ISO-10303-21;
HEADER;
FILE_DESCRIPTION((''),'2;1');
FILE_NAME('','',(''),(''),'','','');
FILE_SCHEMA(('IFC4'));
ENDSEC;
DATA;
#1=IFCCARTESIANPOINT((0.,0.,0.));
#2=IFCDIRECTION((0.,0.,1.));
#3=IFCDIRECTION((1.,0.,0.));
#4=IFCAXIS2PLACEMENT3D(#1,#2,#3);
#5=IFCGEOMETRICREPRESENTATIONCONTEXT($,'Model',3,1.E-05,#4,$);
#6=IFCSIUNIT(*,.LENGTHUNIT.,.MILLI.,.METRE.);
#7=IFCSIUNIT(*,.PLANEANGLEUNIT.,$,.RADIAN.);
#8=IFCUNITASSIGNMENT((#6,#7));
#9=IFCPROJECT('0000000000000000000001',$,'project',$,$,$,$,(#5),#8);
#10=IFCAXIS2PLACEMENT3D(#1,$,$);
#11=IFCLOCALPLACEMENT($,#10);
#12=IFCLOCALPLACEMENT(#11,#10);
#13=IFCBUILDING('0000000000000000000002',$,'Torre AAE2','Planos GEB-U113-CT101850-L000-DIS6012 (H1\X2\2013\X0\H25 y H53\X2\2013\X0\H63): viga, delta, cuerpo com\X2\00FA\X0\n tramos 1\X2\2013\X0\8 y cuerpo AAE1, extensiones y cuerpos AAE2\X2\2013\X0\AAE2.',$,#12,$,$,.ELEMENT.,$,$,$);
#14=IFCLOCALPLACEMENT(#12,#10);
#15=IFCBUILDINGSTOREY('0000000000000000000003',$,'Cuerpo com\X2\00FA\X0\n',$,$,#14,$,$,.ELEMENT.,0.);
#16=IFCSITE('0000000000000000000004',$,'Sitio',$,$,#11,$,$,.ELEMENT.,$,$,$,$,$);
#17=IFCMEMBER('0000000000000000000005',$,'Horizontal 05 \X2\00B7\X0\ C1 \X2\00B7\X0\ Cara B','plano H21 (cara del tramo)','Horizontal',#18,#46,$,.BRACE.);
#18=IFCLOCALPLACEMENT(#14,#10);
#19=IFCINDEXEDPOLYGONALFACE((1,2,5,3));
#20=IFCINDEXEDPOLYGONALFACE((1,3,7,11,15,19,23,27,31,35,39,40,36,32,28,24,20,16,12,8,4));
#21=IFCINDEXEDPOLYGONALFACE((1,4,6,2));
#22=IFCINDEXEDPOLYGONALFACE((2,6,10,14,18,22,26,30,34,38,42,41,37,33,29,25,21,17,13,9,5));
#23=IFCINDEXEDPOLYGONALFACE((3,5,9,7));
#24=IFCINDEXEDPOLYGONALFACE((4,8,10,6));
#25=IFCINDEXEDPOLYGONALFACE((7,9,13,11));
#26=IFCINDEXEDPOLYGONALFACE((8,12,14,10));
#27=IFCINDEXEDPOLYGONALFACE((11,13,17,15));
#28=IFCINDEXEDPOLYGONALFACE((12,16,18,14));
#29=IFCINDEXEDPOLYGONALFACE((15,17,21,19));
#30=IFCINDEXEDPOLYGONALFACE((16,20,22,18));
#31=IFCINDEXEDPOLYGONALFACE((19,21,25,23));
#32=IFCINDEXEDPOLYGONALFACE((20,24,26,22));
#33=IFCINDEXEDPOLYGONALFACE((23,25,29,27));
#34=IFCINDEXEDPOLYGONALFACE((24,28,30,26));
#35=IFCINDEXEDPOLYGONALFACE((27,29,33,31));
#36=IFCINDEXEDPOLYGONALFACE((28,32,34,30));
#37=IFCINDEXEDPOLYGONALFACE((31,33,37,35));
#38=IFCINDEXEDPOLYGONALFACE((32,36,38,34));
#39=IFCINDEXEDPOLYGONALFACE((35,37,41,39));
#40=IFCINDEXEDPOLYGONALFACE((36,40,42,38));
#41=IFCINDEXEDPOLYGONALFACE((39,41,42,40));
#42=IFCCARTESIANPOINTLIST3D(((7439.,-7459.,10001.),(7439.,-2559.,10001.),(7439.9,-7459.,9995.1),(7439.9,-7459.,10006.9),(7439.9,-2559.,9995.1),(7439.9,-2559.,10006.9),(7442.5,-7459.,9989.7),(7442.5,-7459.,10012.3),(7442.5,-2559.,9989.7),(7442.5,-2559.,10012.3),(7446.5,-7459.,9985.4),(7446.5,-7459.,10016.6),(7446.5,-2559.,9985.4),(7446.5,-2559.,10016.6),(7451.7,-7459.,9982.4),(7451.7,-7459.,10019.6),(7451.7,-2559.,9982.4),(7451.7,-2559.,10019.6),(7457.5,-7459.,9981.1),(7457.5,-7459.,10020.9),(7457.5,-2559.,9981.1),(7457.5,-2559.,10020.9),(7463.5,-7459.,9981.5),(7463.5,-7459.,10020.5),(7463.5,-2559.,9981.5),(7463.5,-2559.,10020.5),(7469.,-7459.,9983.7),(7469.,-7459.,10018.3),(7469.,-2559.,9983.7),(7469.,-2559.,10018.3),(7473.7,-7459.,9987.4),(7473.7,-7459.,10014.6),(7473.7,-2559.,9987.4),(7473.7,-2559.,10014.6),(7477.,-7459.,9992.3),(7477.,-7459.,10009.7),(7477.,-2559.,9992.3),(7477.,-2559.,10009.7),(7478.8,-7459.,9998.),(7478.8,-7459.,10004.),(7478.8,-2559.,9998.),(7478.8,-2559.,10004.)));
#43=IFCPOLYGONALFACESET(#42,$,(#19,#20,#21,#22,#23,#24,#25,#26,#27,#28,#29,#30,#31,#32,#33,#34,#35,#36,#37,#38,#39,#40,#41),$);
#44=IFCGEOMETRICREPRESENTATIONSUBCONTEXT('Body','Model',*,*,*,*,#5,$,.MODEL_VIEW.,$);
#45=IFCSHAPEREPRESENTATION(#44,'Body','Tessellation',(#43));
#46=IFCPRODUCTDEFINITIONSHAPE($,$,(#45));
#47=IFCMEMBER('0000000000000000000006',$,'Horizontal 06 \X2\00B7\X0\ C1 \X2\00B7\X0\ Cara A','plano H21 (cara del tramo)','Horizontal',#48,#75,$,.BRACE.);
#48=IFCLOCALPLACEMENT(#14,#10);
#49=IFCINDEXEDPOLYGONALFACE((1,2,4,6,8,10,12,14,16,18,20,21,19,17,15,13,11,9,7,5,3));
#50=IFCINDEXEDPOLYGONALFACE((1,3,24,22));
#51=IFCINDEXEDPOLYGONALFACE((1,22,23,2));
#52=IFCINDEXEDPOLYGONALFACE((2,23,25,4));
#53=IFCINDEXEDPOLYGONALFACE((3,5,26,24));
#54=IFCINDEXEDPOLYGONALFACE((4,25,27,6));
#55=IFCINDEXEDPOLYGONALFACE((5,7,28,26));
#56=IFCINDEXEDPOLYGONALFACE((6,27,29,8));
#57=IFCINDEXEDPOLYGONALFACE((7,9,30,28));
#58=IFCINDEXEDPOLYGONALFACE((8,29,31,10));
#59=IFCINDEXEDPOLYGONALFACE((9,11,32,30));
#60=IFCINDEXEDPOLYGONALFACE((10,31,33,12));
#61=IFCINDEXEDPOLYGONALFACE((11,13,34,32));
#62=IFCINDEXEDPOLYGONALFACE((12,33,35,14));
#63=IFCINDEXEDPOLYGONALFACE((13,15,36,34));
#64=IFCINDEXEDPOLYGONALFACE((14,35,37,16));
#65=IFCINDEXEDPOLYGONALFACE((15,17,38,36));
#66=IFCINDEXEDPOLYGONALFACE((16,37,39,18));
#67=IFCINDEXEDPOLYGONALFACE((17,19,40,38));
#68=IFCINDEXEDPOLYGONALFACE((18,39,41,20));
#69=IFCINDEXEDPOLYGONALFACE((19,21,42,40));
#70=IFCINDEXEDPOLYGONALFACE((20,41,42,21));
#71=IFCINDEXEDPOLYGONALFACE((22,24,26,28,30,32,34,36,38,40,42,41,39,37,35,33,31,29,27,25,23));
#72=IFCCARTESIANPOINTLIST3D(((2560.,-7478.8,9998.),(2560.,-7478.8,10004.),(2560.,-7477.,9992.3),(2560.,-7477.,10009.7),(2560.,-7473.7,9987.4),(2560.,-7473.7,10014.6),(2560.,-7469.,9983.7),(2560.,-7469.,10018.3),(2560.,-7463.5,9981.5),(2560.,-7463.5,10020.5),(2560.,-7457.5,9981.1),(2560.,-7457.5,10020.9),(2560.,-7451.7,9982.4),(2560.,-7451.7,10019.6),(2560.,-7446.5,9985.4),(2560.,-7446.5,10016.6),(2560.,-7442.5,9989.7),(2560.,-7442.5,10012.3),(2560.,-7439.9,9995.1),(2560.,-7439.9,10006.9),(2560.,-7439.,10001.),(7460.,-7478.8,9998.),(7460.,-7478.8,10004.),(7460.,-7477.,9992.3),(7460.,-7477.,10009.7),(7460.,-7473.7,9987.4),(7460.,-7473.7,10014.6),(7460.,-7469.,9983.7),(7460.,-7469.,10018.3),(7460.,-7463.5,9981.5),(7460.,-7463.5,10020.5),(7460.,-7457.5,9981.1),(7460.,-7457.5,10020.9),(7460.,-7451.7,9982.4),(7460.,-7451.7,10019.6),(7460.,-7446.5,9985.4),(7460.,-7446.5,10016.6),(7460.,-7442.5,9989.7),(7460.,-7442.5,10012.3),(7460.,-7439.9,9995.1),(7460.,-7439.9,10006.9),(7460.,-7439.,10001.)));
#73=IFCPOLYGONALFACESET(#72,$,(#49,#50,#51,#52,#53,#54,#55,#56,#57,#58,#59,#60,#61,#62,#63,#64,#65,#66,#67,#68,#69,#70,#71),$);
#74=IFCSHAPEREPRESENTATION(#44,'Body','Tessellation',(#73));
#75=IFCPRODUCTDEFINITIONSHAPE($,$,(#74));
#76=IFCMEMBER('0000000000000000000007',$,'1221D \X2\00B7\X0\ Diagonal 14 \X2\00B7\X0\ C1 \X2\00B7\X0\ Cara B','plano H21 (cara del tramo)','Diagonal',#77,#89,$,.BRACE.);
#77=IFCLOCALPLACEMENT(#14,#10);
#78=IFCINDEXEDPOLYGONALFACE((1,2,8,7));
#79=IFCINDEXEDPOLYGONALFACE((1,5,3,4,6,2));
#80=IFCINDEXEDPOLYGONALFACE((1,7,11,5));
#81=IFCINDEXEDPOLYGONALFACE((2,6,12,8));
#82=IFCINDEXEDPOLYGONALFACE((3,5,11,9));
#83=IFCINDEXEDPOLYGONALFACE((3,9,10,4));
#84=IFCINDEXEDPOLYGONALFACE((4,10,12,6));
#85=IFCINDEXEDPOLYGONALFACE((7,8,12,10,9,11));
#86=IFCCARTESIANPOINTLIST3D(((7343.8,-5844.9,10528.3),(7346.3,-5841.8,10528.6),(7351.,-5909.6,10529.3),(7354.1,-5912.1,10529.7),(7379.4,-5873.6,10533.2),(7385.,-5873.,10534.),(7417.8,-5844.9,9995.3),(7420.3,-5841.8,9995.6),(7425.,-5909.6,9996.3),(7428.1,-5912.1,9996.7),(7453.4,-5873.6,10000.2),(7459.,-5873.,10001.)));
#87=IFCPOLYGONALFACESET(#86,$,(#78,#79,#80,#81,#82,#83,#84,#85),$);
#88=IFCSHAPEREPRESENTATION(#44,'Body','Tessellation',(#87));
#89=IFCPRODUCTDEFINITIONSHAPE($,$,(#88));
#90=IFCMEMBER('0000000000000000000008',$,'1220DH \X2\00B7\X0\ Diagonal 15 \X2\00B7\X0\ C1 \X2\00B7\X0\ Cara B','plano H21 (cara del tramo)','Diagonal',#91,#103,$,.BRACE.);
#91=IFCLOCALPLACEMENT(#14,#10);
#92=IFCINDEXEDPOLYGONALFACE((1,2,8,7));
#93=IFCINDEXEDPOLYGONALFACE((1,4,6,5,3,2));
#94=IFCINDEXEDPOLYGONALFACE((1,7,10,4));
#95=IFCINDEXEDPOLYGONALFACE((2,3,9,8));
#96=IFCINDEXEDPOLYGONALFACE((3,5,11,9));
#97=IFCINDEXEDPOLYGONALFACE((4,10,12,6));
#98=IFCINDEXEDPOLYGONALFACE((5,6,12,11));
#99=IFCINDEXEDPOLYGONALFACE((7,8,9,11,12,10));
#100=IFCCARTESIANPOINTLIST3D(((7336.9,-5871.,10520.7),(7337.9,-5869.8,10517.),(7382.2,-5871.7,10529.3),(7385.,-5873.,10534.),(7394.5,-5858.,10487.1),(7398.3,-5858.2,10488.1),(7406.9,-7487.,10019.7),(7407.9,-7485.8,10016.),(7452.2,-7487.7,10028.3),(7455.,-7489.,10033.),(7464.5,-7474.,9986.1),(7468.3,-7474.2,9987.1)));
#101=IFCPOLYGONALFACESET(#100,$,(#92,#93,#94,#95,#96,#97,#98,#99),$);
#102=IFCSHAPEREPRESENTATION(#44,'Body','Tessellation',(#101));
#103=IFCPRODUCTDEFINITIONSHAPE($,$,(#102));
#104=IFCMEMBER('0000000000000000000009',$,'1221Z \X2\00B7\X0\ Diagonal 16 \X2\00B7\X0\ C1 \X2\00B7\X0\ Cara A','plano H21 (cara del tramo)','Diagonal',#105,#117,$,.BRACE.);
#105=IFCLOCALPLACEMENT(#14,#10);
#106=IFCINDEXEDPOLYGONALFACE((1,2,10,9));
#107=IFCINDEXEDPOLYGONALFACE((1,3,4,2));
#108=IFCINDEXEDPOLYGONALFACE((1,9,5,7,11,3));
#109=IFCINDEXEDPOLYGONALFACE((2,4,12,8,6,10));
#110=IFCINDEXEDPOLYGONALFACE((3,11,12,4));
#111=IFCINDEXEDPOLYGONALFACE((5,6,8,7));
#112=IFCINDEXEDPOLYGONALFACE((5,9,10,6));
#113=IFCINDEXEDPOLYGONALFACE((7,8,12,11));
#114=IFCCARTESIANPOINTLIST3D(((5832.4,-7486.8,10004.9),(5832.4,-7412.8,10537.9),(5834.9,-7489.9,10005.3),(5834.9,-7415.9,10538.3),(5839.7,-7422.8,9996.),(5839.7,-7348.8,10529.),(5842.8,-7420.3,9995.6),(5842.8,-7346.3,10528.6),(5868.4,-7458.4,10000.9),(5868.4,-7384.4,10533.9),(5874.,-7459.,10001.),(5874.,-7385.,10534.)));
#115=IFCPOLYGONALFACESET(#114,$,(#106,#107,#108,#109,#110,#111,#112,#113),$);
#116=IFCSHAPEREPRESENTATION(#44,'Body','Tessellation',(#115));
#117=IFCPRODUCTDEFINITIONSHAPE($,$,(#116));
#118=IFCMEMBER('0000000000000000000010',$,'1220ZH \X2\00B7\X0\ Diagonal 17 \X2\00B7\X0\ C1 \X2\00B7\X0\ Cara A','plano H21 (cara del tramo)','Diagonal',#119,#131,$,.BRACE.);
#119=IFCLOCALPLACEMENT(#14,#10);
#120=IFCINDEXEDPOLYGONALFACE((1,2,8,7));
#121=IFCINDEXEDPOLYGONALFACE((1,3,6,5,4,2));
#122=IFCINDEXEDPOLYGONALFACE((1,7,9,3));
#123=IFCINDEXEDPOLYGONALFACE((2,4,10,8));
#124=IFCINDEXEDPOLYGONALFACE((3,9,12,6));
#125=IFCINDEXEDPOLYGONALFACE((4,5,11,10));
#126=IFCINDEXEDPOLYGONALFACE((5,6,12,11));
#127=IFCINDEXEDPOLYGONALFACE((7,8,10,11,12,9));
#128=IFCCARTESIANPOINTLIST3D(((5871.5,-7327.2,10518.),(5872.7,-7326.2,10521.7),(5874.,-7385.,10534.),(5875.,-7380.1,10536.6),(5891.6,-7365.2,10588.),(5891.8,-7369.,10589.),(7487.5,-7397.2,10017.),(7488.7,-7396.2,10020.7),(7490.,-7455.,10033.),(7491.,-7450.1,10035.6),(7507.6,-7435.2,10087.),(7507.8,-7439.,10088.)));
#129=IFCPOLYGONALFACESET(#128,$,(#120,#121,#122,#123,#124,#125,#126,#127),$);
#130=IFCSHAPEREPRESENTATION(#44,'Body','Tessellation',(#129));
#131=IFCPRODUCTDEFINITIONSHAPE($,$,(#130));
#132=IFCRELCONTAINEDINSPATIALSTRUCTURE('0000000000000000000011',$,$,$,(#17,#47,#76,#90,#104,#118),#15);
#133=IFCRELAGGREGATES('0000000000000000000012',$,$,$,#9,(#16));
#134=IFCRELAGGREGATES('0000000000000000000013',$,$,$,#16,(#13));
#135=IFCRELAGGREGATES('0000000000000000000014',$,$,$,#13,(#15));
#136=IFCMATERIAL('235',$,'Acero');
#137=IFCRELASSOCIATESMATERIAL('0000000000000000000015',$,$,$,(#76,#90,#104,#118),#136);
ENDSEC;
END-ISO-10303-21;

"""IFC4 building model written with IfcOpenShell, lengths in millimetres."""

from ifc_helpers import new_model, si_unit, frame, frame_2d, origin, origin_with_axes, place, context, subcontext, project, spatial, circle, l_section, extrude, material, element, save


model = new_model("IFC4")

# Units and contexts
model_context = context("Model", 3, precision=1e-05, world=origin_with_axes())
body_context = subcontext(model_context, "Body", "Model", "MODEL_VIEW")
ifc_project = project(units=[si_unit("LENGTHUNIT", "METRE", prefix="MILLI"), si_unit("PLANEANGLEUNIT", "RADIAN")], contexts=[model_context])

# Site, building, storey
site_placement = place(None, origin())
site = spatial("IfcSite", under=ifc_project, at=site_placement, Name="Sitio", CompositionType="ELEMENT")
building_placement = place(site_placement, origin())
building = spatial("IfcBuilding", under=site, at=building_placement, Name="Torre AAE2", Description="Planos GEB-U113-CT101850-L000-DIS6012 (H1–H25 y H53–H63): viga, delta, cuerpo común tramos 1–8 y cuerpo AAE1, extensiones y cuerpos AAE2–AAE2.", CompositionType="ELEMENT")
storey_placement = place(building_placement, origin())
storey = spatial("IfcBuildingStorey", under=building, at=storey_placement, Name="Cuerpo común", CompositionType="ELEMENT", Elevation=0.0)

# Members
ifc_material_1 = material(Name="235", Category="Acero")
for number, where, z_axis, x_axis, name in (
    (1, (7459.0, -7459.0, 10001.0), (0.0, 1.0, 0.0), (-1.0, 0.0, 0.0), "Horizontal 05 · C1 · Cara B"),
    (2, (7460.0, -7459.0, 10001.0), (-1.0, 0.0, 0.0), (0.0, 1.0, 0.0), "Horizontal 06 · C1 · Cara A"),
):
    element("IfcMember", number, at=place(storey_placement, frame(where, z_axis=z_axis, x_axis=x_axis)), inside=storey, Name=name, Description="plano H21 (cara del tramo)", ObjectType="Horizontal", PredefinedType="BRACE", context=body_context, shape_type="SweptSolid", body=[
        extrude(circle(Radius=20.0), None, (0.0, 0.0, 1.0), 4900.0),
    ])
member_1_placement = place(storey_placement, frame((7459.0, -5873.0, 10001.0), z_axis=(-0.137518, 0.0, 0.990499), x_axis=(-0.77387, 0.624164, -0.107442)))
element("IfcMember", 3, at=member_1_placement, inside=storey, material=ifc_material_1, Name="1221D · Diagonal 14 · C1 · Cara B", Description="plano H21 (cara del tramo)", ObjectType="Diagonal", PredefinedType="BRACE", context=body_context, shape_type="SweptSolid", body=[
    extrude(l_section(Depth=50.0, Width=50.0, Thickness=4.0, at=frame_2d((25.0, 25.0))), None, (0.0, 0.0, 1.0), 538.1),
])
member_2_placement = place(storey_placement, frame((7385.0, -5873.0, 10534.0), z_axis=(0.041339, -0.954334, -0.295867), x_axis=(-0.962961, 0.040915, -0.266519)))
element("IfcMember", 4, at=member_2_placement, inside=storey, material=ifc_material_1, Name="1220DH · Diagonal 15 · C1 · Cara B", Description="plano H21 (cara del tramo)", ObjectType="Diagonal", PredefinedType="BRACE", context=body_context, shape_type="SweptSolid", body=[
    extrude(l_section(Depth=50.0, Width=50.0, Thickness=4.0, at=frame_2d((25.0, 25.0))), None, (0.0, 0.0, 1.0), 1693.3),
])
member_3_placement = place(storey_placement, frame((5874.0, -7459.0, 10001.0), z_axis=(0.0, 0.137518, 0.990499), x_axis=(-0.624229, 0.773819, -0.107435)))
element("IfcMember", 5, at=member_3_placement, inside=storey, material=ifc_material_1, Name="1221Z · Diagonal 16 · C1 · Cara A", Description="plano H21 (cara del tramo)", ObjectType="Diagonal", PredefinedType="BRACE", context=body_context, shape_type="SweptSolid", body=[
    extrude(l_section(Depth=50.0, Width=50.0, Thickness=4.0, at=frame_2d((25.0, 25.0))), None, (0.0, 0.0, 1.0), 538.1),
])
member_4_placement = place(storey_placement, frame((5874.0, -7385.0, 10534.0), z_axis=(0.954334, -0.041339, -0.295867), x_axis=(-0.040927, 0.96295, -0.266555)))
element("IfcMember", 6, at=member_4_placement, inside=storey, material=ifc_material_1, Name="1220ZH · Diagonal 17 · C1 · Cara A", Description="plano H21 (cara del tramo)", ObjectType="Diagonal", PredefinedType="BRACE", context=body_context, shape_type="SweptSolid", body=[
    extrude(l_section(Depth=60.0, Width=60.0, Thickness=4.0, at=frame_2d((30.0, 30.0))), None, (0.0, 0.0, 1.0), 1693.3),
])

save(model, "model.ifc")
